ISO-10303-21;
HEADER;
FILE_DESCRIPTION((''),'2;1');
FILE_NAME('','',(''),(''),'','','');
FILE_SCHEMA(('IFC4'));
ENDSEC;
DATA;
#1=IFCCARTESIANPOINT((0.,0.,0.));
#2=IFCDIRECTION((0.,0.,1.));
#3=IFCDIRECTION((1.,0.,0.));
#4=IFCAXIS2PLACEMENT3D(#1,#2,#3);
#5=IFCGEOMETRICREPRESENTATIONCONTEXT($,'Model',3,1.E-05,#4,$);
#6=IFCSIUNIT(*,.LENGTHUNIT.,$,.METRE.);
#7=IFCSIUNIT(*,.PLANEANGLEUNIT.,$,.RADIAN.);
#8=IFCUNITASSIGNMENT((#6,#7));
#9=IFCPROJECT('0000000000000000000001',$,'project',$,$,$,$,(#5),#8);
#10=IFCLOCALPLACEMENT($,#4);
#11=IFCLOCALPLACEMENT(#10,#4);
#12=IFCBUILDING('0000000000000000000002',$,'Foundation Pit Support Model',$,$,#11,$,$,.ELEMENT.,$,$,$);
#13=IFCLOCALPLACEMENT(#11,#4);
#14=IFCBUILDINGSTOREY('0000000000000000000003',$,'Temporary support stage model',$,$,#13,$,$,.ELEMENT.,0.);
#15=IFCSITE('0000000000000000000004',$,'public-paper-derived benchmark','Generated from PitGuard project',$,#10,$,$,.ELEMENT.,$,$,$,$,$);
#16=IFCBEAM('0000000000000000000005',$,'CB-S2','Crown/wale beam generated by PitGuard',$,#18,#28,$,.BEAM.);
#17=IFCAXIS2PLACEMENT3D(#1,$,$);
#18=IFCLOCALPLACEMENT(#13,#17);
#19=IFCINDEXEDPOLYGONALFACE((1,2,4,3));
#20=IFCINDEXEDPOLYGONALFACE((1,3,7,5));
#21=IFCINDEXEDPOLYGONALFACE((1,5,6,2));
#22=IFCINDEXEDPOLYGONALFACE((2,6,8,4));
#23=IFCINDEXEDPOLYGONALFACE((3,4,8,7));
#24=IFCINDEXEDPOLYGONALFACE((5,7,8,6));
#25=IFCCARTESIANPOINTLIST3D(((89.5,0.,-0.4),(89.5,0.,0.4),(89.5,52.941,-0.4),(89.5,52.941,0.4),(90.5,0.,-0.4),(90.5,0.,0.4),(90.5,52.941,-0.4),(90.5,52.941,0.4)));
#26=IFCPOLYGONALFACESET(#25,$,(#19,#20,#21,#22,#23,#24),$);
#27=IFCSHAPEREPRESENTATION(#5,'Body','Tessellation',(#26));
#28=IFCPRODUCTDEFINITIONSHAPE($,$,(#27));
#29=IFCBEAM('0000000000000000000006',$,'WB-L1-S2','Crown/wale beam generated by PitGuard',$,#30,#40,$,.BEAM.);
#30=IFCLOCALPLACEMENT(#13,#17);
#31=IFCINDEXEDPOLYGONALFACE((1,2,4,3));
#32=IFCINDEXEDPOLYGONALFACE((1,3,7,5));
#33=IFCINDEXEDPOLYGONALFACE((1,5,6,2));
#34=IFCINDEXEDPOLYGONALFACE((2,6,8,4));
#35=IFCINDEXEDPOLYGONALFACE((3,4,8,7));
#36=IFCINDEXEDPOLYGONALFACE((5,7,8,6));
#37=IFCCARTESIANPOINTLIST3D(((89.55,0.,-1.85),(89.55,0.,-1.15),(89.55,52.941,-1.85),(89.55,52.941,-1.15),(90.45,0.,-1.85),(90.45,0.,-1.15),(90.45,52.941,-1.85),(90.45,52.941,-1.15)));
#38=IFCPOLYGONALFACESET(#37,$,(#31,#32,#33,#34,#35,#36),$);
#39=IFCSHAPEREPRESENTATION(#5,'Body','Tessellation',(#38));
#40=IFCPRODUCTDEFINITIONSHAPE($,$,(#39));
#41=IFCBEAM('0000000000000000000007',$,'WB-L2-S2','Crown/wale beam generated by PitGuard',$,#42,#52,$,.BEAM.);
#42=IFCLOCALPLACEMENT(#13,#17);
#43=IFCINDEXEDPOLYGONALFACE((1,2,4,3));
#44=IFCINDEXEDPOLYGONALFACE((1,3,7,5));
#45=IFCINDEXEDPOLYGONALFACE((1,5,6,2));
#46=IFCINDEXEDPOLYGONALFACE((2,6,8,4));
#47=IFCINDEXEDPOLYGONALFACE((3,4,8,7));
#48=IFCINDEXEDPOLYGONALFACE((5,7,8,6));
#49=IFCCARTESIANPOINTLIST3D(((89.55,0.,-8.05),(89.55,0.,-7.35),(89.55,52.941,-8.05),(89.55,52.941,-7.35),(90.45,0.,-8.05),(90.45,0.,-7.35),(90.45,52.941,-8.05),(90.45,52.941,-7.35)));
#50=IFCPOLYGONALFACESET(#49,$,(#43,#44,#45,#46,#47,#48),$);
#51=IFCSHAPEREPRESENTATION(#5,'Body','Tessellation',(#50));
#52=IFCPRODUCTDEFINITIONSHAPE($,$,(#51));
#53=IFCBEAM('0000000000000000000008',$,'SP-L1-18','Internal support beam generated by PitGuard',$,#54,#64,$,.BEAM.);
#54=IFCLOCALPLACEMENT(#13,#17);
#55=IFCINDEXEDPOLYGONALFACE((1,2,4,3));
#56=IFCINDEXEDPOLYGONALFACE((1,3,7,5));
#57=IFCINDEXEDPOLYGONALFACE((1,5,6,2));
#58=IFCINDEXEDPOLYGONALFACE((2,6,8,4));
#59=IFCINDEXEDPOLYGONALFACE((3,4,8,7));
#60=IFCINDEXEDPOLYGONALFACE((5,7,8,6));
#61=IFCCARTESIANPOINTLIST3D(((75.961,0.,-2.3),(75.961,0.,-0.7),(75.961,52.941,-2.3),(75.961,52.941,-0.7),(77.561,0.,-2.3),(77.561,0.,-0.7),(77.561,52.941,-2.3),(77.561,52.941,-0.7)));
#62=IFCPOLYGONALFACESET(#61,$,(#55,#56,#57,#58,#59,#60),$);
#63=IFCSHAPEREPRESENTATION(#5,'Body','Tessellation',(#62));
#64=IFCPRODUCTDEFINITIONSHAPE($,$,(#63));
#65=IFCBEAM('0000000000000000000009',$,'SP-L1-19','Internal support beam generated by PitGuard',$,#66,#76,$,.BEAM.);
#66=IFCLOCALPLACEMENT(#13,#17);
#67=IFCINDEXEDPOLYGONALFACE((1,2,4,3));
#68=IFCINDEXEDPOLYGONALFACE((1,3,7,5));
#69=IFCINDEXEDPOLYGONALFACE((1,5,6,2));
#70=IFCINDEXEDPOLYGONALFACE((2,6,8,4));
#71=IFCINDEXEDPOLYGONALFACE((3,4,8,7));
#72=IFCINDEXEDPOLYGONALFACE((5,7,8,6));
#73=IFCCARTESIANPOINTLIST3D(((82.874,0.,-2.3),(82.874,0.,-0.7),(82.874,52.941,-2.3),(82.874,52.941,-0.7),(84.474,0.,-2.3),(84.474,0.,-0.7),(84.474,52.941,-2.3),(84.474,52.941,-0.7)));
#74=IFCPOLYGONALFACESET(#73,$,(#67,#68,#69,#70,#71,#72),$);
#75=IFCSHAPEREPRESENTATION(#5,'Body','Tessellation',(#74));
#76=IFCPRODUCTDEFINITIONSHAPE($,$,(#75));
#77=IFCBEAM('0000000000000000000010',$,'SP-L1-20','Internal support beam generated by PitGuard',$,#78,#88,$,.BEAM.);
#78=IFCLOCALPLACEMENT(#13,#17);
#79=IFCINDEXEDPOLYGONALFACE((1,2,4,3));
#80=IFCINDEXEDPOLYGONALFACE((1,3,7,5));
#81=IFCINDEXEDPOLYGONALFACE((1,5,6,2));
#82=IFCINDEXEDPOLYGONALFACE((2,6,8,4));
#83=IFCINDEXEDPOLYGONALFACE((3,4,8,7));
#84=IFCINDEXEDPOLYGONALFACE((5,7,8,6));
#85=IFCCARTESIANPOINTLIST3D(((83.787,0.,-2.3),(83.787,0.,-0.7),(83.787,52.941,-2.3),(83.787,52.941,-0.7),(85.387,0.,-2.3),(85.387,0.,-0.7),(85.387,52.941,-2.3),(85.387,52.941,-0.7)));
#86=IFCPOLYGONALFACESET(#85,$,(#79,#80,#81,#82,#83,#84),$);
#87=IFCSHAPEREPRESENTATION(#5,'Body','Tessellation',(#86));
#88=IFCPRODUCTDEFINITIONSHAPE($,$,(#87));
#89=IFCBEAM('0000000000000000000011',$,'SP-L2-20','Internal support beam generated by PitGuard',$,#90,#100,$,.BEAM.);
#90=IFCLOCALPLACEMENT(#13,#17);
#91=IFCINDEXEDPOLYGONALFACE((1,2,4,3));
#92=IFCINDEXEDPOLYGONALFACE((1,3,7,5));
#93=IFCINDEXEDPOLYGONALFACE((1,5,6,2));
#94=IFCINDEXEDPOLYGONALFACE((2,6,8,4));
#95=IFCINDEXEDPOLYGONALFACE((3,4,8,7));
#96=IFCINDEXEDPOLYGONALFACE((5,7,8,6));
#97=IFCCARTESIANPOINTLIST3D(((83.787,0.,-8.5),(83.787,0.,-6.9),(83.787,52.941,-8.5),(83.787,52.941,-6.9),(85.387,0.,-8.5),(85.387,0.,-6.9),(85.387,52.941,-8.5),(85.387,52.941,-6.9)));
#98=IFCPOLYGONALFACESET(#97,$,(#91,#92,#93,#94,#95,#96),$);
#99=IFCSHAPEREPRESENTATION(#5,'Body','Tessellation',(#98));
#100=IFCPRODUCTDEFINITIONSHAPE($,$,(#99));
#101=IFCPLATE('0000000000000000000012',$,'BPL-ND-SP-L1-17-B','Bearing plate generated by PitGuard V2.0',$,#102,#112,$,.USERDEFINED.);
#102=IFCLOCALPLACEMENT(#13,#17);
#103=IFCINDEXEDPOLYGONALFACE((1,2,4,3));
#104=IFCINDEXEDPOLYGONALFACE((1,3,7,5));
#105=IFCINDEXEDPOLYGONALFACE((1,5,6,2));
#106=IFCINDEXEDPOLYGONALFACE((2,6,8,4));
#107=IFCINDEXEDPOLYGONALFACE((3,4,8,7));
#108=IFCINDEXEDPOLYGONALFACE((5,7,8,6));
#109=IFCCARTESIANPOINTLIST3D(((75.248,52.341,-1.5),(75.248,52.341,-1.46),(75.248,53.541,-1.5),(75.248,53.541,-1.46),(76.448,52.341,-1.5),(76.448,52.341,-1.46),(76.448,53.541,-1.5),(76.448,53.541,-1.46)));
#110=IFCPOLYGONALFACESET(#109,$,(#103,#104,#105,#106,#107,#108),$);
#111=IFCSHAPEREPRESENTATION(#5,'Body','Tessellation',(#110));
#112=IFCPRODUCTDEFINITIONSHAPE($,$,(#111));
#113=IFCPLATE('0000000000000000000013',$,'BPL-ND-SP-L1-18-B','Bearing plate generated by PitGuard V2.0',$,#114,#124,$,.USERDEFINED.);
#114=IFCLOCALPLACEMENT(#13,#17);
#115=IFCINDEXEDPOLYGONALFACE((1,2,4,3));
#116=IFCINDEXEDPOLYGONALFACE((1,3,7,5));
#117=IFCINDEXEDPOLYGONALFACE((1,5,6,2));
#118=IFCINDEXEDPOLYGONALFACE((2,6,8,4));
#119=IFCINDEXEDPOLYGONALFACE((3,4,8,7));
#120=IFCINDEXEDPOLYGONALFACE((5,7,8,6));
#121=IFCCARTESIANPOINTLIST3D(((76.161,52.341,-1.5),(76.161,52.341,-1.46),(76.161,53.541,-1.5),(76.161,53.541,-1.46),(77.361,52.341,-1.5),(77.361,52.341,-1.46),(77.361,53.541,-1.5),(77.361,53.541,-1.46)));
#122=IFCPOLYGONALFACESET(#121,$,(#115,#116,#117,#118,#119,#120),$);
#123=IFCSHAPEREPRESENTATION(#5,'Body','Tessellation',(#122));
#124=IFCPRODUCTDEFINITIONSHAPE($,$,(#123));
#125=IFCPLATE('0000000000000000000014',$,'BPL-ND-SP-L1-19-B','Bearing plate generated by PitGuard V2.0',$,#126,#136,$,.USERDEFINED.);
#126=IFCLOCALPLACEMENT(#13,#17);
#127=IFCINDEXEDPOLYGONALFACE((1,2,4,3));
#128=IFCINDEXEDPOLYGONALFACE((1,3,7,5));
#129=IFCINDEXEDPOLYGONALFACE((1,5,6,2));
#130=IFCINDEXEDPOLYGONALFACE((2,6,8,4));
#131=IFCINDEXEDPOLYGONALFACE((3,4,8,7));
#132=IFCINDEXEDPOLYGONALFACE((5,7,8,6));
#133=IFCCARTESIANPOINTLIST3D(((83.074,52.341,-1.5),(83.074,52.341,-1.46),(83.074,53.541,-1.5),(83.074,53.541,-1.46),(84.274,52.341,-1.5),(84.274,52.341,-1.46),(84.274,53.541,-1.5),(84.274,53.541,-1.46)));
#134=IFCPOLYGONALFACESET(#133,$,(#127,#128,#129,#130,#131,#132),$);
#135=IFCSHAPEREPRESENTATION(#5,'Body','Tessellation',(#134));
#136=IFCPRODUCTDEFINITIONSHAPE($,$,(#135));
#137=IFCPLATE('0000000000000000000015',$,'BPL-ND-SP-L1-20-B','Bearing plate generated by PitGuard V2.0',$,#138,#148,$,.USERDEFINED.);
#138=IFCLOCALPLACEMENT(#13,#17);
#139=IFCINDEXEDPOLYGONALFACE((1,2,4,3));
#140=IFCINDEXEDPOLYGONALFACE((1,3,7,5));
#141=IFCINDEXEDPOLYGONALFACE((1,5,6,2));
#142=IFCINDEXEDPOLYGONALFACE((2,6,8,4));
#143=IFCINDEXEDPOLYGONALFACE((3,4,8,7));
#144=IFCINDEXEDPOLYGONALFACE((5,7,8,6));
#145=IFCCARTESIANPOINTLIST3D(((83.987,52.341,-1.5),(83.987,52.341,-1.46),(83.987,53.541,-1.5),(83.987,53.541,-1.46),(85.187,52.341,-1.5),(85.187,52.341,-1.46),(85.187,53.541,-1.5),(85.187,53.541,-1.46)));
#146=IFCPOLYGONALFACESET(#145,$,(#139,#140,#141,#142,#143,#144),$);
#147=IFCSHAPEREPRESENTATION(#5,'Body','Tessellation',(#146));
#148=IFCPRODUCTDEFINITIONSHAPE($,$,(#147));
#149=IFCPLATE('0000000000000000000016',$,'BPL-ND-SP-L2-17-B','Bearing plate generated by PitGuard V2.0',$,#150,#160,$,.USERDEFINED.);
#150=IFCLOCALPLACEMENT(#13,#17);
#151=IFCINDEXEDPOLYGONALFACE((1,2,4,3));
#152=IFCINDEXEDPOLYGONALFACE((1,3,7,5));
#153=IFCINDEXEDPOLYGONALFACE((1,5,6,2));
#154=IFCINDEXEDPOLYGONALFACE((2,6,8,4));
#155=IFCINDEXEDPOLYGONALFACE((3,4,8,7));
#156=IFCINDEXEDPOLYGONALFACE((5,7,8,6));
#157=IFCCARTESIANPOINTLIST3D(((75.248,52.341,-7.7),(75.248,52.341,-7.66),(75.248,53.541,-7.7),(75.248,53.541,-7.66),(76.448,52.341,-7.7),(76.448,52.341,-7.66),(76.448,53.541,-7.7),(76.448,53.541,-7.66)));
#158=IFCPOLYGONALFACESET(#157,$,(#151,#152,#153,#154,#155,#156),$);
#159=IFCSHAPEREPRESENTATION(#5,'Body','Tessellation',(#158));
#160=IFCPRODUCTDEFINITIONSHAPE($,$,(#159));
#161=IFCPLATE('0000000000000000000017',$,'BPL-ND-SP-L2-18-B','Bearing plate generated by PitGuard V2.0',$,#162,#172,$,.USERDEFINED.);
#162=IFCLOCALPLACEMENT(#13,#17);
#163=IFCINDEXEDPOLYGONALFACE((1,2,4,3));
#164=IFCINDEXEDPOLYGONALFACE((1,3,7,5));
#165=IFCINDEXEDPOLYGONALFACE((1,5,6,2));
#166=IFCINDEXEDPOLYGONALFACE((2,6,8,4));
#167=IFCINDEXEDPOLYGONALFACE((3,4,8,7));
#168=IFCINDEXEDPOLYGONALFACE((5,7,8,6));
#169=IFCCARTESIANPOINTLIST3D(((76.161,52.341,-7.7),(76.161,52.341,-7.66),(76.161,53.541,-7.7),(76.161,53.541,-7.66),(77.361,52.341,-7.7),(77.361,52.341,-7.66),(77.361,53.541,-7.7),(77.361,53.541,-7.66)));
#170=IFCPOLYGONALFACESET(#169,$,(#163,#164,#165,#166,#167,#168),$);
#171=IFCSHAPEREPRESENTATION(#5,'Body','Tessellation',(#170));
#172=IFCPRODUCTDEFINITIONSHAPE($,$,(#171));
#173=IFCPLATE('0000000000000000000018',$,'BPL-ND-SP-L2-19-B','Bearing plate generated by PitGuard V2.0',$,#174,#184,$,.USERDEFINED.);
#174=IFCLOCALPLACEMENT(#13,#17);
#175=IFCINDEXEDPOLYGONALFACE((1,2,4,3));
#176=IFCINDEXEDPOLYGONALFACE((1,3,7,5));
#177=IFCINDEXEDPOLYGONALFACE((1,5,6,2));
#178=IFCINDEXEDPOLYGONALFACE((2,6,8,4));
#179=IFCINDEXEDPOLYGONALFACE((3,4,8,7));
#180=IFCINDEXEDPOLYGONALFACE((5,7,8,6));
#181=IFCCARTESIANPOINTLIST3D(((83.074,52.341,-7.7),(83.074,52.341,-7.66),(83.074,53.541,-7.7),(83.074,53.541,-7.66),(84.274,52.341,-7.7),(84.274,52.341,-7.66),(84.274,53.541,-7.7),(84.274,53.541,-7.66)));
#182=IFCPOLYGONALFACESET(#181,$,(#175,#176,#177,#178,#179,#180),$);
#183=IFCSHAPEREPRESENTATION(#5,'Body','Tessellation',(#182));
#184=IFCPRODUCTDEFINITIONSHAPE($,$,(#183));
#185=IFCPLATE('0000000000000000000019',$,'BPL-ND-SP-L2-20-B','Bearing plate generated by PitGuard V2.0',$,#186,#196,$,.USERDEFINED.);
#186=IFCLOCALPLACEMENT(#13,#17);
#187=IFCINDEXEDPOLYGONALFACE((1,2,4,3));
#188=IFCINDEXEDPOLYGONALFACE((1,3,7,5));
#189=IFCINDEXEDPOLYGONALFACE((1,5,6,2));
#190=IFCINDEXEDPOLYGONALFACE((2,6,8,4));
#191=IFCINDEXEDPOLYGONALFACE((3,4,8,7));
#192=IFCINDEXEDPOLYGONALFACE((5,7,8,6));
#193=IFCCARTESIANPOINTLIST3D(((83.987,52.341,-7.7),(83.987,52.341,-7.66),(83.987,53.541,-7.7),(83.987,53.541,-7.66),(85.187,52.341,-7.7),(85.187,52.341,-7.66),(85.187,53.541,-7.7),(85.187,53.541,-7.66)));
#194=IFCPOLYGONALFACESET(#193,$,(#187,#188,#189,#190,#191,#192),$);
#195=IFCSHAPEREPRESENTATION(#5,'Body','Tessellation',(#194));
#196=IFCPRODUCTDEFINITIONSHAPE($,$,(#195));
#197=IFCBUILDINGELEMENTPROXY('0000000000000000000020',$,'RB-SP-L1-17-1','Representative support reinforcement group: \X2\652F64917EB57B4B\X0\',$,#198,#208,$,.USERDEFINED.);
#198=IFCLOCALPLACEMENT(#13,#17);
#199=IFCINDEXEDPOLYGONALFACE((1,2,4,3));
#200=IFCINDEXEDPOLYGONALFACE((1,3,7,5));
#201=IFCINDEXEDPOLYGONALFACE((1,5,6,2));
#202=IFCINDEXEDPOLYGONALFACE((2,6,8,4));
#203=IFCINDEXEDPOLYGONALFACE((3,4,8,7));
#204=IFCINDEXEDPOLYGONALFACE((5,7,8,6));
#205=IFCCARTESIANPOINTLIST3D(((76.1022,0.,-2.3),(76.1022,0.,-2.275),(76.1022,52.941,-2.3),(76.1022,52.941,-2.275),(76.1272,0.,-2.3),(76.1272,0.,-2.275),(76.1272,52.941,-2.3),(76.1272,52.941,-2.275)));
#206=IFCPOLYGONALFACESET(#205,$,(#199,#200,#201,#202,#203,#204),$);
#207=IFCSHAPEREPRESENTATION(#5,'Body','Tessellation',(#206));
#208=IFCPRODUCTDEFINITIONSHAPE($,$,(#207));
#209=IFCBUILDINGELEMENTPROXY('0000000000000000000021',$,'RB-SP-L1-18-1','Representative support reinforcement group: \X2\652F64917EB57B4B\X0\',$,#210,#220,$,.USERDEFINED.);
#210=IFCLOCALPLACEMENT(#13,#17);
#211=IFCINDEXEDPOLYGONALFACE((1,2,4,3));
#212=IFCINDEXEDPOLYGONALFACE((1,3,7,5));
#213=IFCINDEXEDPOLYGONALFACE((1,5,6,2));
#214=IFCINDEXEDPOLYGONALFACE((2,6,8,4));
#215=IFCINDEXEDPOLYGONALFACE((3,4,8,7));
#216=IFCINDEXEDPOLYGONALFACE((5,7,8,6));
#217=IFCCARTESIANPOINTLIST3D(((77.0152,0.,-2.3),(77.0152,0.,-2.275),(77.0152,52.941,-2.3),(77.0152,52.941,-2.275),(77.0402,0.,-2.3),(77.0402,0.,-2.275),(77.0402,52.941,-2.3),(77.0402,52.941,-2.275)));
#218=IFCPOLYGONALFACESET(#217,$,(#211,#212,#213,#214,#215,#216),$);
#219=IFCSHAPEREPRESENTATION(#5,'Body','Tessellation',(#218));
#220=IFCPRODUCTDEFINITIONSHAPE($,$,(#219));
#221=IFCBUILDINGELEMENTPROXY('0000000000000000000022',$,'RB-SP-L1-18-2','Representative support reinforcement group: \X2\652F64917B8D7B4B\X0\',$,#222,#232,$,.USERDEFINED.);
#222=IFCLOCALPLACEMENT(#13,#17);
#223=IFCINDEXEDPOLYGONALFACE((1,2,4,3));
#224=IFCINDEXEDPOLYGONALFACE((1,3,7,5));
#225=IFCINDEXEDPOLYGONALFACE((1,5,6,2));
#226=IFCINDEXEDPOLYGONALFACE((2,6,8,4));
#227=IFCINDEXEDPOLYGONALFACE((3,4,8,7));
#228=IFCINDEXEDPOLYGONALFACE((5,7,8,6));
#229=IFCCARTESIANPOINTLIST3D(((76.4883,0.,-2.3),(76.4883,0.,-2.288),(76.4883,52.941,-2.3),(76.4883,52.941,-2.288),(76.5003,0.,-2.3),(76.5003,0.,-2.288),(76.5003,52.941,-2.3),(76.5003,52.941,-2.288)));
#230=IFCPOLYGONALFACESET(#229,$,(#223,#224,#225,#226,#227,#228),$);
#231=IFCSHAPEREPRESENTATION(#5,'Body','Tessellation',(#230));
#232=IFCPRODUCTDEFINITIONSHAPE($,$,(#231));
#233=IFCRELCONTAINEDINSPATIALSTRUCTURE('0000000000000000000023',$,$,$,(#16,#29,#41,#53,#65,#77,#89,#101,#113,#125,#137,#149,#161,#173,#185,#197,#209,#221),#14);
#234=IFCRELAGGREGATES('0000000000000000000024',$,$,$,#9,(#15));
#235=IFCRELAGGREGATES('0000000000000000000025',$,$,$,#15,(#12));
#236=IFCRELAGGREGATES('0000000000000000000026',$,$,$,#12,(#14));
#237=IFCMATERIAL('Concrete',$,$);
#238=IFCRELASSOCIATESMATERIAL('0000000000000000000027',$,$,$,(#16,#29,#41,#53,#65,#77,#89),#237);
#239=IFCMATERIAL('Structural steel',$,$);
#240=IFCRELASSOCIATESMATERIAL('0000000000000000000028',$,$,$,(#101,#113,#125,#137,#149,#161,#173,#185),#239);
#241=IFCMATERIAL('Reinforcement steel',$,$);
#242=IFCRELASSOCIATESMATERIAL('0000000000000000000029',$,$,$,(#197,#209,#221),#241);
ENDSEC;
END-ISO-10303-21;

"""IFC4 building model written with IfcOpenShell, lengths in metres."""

from ifc_helpers import new_model, si_unit, frame, origin_with_axes, origin_2d, place, context, project, spatial, rectangle, extrude, material, element, save


model = new_model("IFC4")

# Units and contexts
model_context = context("Model", 3, precision=1e-05, world=origin_with_axes())
ifc_project = project(units=[si_unit("LENGTHUNIT", "METRE"), si_unit("PLANEANGLEUNIT", "RADIAN")], contexts=[model_context])

# Site, building, storey
site_placement = place(None, origin_with_axes())
site = spatial("IfcSite", under=ifc_project, at=site_placement, Name="public-paper-derived benchmark", Description="Generated from PitGuard project", CompositionType="ELEMENT")
building_placement = place(site_placement, origin_with_axes())
building = spatial("IfcBuilding", under=site, at=building_placement, Name="Foundation Pit Support Model", CompositionType="ELEMENT")
storey_placement = place(building_placement, origin_with_axes())
storey = spatial("IfcBuildingStorey", under=building, at=storey_placement, Name="Temporary support stage model", CompositionType="ELEMENT", Elevation=0.0)

# Beams
ifc_material_1 = material(Name="Concrete")
beam_placement = place(storey_placement, frame((90.0, 26.4705, -0.4), z_axis=(0.0, 0.0, 1.0), x_axis=(0.0, 1.0, 0.0)))
element("IfcBeam", 1, at=beam_placement, inside=storey, material=ifc_material_1, Name="CB-S2", Description="Crown/wale beam generated by PitGuard", PredefinedType="BEAM", context=model_context, shape_type="SweptSolid", body=[
    extrude(rectangle(XDim=52.941, YDim=1.0, at=origin_2d()), origin_with_axes(), (0.0, 0.0, 1.0), 0.8),
])
for number, where, z_axis, x_axis, name in (
    (2, (90.0, 26.4705, -1.85), (0.0, 0.0, 1.0), (0.0, 1.0, 0.0), "WB-L1-S2"),
    (3, (90.0, 26.4705, -8.05), (0.0, 0.0, 1.0), (0.0, 1.0, 0.0), "WB-L2-S2"),
):
    element("IfcBeam", number, at=place(storey_placement, frame(where, z_axis=z_axis, x_axis=x_axis)), inside=storey, material=ifc_material_1, Name=name, Description="Crown/wale beam generated by PitGuard", PredefinedType="BEAM", context=model_context, shape_type="SweptSolid", body=[
        extrude(rectangle(XDim=52.941, YDim=0.9, at=origin_2d()), origin_with_axes(), (0.0, 0.0, 1.0), 0.7),
    ])
for number, where, z_axis, x_axis, name in (
    (4, (76.761, 26.4705, -2.3), (0.0, 0.0, 1.0), (0.0, 1.0, 0.0), "SP-L1-18"),
    (5, (83.674, 26.4705, -2.3), (0.0, 0.0, 1.0), (0.0, 1.0, 0.0), "SP-L1-19"),
    (6, (84.587, 26.4705, -2.3), (0.0, 0.0, 1.0), (0.0, 1.0, 0.0), "SP-L1-20"),
    (7, (84.587, 26.4705, -8.5), (0.0, 0.0, 1.0), (0.0, 1.0, 0.0), "SP-L2-20"),
):
    element("IfcBeam", number, at=place(storey_placement, frame(where, z_axis=z_axis, x_axis=x_axis)), inside=storey, material=ifc_material_1, Name=name, Description="Internal support beam generated by PitGuard", PredefinedType="BEAM", context=model_context, shape_type="SweptSolid", body=[
        extrude(rectangle(XDim=52.941, YDim=1.6, at=origin_2d()), origin_with_axes(), (0.0, 0.0, 1.0), 1.6),
    ])

# Plates
ifc_material_2 = material(Name="Structural steel")
for number, where, z_axis, x_axis, name in (
    (8, (75.848, 52.941, -1.5), (0.0, 0.0, 1.0), (1.0, 0.0, 0.0), "BPL-ND-SP-L1-17-B"),
    (9, (76.761, 52.941, -1.5), (0.0, 0.0, 1.0), (1.0, 0.0, 0.0), "BPL-ND-SP-L1-18-B"),
    (10, (83.674, 52.941, -1.5), (0.0, 0.0, 1.0), (1.0, 0.0, 0.0), "BPL-ND-SP-L1-19-B"),
    (11, (84.587, 52.941, -1.5), (0.0, 0.0, 1.0), (1.0, 0.0, 0.0), "BPL-ND-SP-L1-20-B"),
    (12, (75.848, 52.941, -7.7), (0.0, 0.0, 1.0), (1.0, 0.0, 0.0), "BPL-ND-SP-L2-17-B"),
    (13, (76.761, 52.941, -7.7), (0.0, 0.0, 1.0), (1.0, 0.0, 0.0), "BPL-ND-SP-L2-18-B"),
    (14, (83.674, 52.941, -7.7), (0.0, 0.0, 1.0), (1.0, 0.0, 0.0), "BPL-ND-SP-L2-19-B"),
    (15, (84.587, 52.941, -7.7), (0.0, 0.0, 1.0), (1.0, 0.0, 0.0), "BPL-ND-SP-L2-20-B"),
):
    element("IfcPlate", number, at=place(storey_placement, frame(where, z_axis=z_axis, x_axis=x_axis)), inside=storey, material=ifc_material_2, Name=name, Description="Bearing plate generated by PitGuard V2.0", PredefinedType="USERDEFINED", context=model_context, shape_type="SweptSolid", body=[
        extrude(rectangle(XDim=1.2, YDim=1.2, at=origin_2d()), origin_with_axes(), (0.0, 0.0, 1.0), 0.04),
    ])

# Building element proxies
ifc_material_3 = material(Name="Reinforcement steel")
for number, where, z_axis, x_axis, name in (
    (16, (76.1147, 26.4705, -2.3), (0.0, 0.0, 1.0), (0.0, 1.0, 0.0), "RB-SP-L1-17-1"),
    (17, (77.0277, 26.4705, -2.3), (0.0, 0.0, 1.0), (0.0, 1.0, 0.0), "RB-SP-L1-18-1"),
):
    element("IfcBuildingElementProxy", number, at=place(storey_placement, frame(where, z_axis=z_axis, x_axis=x_axis)), inside=storey, material=ifc_material_3, Name=name, Description="Representative support reinforcement group: 支撑纵筋", PredefinedType="USERDEFINED", context=model_context, shape_type="SweptSolid", body=[
        extrude(rectangle(XDim=52.941, YDim=0.025, at=origin_2d()), origin_with_axes(), (0.0, 0.0, 1.0), 0.025),
    ])
proxy_1_placement = place(storey_placement, frame((76.4943, 26.4705, -2.3), z_axis=(0.0, 0.0, 1.0), x_axis=(0.0, 1.0, 0.0)))
element("IfcBuildingElementProxy", 18, at=proxy_1_placement, inside=storey, material=ifc_material_3, Name="RB-SP-L1-18-2", Description="Representative support reinforcement group: 支撑箍筋", PredefinedType="USERDEFINED", context=model_context, shape_type="SweptSolid", body=[
    extrude(rectangle(XDim=52.941, YDim=0.012, at=origin_2d()), origin_with_axes(), (0.0, 0.0, 1.0), 0.012),
])

save(model, "model.ifc")
